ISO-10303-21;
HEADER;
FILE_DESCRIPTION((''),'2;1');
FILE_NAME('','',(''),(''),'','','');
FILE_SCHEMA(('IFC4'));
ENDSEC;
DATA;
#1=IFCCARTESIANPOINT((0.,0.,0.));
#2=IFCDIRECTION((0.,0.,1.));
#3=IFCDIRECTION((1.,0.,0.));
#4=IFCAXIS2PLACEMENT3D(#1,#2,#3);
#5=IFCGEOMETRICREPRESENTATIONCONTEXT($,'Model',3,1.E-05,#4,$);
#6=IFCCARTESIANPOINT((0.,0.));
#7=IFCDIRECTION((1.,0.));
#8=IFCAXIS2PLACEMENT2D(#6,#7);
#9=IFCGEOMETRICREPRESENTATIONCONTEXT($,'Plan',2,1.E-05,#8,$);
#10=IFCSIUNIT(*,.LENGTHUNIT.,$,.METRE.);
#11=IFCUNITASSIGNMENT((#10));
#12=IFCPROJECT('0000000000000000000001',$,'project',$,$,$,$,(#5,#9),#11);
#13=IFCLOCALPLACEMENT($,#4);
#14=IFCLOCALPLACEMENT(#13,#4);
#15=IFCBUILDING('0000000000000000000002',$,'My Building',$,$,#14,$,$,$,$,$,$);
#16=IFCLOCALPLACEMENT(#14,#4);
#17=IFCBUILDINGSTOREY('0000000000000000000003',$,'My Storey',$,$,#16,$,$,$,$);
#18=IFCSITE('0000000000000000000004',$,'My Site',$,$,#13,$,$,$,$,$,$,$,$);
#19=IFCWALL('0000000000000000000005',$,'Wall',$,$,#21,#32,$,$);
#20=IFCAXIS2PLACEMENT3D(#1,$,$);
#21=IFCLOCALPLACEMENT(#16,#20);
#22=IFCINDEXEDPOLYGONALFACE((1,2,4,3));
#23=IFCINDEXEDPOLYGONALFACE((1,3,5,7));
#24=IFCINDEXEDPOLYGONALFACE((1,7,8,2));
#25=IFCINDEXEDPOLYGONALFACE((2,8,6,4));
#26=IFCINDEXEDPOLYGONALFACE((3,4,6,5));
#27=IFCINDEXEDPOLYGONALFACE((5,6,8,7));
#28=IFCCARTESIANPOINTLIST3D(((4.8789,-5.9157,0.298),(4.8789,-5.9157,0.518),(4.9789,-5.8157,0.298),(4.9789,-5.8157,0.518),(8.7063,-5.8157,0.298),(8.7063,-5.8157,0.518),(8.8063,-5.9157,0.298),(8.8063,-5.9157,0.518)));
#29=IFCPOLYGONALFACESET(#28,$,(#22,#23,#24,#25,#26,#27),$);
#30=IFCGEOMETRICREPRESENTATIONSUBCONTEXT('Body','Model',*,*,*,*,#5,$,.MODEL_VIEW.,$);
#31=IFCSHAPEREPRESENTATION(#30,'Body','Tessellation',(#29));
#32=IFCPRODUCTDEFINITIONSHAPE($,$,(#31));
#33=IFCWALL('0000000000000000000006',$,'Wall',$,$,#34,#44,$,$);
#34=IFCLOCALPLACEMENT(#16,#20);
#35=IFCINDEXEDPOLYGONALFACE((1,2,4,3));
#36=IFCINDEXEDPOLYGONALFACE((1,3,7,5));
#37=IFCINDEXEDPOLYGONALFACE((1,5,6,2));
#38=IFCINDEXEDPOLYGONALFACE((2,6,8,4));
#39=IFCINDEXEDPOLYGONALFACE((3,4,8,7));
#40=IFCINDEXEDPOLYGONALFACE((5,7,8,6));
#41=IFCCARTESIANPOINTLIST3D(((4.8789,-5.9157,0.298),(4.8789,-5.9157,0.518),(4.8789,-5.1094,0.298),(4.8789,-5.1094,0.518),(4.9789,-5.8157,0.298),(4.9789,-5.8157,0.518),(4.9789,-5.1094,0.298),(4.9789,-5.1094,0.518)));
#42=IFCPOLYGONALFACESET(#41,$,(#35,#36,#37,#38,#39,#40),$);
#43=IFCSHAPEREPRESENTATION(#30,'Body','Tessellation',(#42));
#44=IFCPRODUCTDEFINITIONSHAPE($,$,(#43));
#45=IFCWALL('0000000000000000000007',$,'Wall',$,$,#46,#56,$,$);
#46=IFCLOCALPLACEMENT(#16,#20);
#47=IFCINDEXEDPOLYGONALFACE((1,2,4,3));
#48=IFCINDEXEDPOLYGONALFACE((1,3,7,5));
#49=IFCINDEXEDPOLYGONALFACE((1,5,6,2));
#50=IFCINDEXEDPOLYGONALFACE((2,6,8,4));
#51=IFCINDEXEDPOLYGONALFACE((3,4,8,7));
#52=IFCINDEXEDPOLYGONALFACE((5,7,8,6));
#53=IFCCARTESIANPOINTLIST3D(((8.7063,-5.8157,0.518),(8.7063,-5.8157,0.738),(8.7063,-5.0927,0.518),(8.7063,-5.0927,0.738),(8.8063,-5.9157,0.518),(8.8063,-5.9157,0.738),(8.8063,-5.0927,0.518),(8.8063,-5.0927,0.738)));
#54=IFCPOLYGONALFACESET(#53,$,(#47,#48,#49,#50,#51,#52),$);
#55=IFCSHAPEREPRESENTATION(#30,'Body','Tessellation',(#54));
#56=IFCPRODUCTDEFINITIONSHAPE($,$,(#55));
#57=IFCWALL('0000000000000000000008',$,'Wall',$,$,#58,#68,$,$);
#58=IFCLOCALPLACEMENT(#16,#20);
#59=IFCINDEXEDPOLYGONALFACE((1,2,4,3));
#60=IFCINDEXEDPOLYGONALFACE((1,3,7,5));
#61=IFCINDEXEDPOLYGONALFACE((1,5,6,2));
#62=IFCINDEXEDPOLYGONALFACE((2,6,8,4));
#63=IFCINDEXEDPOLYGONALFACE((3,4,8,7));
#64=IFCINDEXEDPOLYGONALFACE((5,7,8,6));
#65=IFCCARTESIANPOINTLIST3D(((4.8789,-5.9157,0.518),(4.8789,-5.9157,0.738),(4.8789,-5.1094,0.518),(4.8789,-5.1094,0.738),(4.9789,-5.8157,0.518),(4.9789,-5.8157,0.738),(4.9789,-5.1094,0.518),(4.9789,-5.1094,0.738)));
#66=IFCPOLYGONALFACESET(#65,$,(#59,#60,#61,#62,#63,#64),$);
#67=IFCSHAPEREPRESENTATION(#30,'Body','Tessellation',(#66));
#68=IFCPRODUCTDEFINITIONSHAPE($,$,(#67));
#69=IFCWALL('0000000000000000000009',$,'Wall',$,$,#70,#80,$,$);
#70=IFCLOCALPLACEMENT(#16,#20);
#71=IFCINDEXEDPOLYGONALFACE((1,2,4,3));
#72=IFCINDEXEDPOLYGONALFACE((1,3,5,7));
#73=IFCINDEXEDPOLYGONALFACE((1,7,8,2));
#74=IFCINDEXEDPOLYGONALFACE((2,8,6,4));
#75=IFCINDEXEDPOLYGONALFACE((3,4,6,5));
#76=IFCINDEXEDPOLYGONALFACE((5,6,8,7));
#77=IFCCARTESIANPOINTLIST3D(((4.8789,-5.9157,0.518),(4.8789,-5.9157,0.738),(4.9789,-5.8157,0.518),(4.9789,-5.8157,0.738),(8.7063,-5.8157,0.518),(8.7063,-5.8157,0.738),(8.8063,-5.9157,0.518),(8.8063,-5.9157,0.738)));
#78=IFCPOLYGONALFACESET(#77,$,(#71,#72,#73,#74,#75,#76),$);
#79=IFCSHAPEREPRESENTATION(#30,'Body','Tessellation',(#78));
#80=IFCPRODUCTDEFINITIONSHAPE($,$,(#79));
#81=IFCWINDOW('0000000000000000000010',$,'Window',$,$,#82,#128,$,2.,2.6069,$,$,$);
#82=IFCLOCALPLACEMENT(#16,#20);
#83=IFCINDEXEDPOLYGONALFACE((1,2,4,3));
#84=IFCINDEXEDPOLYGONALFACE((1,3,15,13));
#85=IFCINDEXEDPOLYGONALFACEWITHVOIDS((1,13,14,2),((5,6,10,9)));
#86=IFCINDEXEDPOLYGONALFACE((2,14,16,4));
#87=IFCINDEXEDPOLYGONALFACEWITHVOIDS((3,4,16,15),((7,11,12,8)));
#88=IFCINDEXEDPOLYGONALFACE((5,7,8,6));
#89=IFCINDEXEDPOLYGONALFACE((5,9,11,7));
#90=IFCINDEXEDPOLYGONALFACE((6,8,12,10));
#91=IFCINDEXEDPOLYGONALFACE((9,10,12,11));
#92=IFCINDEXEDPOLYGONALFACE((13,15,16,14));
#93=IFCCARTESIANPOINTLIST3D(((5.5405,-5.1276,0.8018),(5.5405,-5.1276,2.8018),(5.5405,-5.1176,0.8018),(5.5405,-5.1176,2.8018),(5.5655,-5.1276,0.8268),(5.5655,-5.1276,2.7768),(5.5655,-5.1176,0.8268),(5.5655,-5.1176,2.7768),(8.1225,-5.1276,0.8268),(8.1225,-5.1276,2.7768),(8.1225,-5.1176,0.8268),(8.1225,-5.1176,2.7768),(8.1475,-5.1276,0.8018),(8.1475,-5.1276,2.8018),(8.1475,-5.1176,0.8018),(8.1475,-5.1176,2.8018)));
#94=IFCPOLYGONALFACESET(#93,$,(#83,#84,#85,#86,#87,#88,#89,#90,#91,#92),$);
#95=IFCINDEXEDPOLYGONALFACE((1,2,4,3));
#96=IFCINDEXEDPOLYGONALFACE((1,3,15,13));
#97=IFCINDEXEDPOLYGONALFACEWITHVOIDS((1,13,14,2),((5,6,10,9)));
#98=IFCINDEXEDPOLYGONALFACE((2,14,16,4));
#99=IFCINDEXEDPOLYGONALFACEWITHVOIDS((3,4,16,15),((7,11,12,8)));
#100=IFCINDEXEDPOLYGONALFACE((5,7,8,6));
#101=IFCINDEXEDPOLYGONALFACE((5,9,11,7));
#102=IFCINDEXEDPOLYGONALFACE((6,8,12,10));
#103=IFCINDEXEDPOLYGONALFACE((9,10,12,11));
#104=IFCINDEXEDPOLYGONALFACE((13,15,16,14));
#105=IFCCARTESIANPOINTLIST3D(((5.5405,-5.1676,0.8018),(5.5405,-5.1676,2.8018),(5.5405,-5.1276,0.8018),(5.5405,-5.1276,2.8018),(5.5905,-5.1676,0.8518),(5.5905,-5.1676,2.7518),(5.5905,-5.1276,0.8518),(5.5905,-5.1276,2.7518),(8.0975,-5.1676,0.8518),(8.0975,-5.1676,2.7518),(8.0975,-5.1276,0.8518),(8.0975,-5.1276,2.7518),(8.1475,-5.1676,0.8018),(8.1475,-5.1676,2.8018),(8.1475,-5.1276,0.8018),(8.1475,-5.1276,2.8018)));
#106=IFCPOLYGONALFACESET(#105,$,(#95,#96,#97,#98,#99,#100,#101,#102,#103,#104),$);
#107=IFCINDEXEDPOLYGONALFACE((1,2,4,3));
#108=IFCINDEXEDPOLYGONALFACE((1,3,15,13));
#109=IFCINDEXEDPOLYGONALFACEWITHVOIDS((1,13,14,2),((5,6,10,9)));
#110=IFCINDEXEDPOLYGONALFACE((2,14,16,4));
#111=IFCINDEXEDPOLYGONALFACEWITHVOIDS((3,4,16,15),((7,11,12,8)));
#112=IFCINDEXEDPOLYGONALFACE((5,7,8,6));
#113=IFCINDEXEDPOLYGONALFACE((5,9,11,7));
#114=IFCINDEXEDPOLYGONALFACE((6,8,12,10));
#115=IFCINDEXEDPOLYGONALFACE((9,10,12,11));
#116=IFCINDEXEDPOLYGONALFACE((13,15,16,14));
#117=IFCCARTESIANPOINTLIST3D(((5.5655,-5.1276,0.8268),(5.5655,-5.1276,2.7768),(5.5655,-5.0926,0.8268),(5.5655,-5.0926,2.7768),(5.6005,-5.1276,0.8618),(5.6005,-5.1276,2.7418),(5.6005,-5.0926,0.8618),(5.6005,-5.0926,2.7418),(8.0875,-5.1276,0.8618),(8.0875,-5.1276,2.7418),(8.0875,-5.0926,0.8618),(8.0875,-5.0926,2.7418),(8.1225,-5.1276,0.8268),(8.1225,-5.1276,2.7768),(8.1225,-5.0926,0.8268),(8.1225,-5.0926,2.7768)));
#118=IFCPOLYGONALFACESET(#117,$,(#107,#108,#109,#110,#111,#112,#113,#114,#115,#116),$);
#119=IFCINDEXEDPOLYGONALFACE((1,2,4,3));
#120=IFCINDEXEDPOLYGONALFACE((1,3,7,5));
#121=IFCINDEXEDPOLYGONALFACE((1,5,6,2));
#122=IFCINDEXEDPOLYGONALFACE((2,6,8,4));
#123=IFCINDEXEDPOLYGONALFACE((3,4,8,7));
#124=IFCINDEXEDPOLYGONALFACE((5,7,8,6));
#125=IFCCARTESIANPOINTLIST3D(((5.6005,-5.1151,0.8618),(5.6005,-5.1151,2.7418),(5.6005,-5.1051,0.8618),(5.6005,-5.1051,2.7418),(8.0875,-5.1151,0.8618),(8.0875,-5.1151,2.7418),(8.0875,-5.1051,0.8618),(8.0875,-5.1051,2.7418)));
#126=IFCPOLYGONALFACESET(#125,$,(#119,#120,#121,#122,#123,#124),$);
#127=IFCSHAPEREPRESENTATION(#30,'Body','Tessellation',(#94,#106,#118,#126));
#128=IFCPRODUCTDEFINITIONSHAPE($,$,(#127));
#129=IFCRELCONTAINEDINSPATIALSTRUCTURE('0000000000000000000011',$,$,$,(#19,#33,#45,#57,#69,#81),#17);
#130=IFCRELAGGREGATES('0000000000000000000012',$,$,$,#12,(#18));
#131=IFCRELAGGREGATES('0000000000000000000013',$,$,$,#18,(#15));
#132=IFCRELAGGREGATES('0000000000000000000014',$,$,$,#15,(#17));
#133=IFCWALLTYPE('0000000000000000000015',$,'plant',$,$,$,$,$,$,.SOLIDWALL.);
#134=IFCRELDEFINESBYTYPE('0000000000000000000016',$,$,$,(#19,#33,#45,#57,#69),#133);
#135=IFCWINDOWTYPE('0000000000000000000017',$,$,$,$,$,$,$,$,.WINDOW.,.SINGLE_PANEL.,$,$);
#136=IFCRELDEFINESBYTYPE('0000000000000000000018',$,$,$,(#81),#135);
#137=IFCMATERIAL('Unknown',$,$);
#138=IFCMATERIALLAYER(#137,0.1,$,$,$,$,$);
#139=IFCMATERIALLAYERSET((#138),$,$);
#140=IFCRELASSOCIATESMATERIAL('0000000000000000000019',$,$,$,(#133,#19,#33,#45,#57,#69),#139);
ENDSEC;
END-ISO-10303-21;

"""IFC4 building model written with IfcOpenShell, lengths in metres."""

from ifc_helpers import new_model, entity, si_unit, frame, origin_with_axes, origin_2d_with_axis, place, context, subcontext, project, spatial, line, indexed_curve, outline, extrude, shape, source, transform, mapped, material, layer, layer_set, layer_usage, type_object, type_shapes, element, save


model = new_model("IFC4")

# Units and contexts
model_context = context("Model", 3, precision=1e-05, world=origin_with_axes())
plan_context = context("Plan", 2, precision=1e-05, world=origin_2d_with_axis())
body_context_1 = subcontext(model_context, "Body", "Model", "MODEL_VIEW")
body_context_2 = subcontext(plan_context, "Body", "Plan", "PLAN_VIEW")
ifc_project = project(units=[si_unit("LENGTHUNIT", "METRE")], contexts=[model_context, plan_context])

# Site, building, storey
site_placement = place(None, origin_with_axes())
site = spatial("IfcSite", under=ifc_project, at=site_placement, Name="My Site")
building_placement = place(site_placement, origin_with_axes())
building = spatial("IfcBuilding", under=site, at=building_placement, Name="My Building")
storey_placement = place(building_placement, origin_with_axes())
storey = spatial("IfcBuildingStorey", under=building, at=storey_placement, Name="My Storey")

# Shared definitions
ifc_material = material(Name="Unknown")

# Walls
ifc_layer_1 = layer(ifc_material, 0.1)
ifc_layer_set_1 = layer_set([ifc_layer_1])
wall_type = type_object("IfcWallType", Name="plant", PredefinedType="SOLIDWALL", material=ifc_layer_set_1)
ifc_layer_usage_1 = layer_usage(ifc_layer_set_1, "AXIS2", "POSITIVE", 0.0)
wall_1_placement = place(storey_placement, frame((8.7063, -5.8157, 0.298), z_axis=(0.0, 0.0, 1.0), x_axis=(-1.0, 0.0, 0.0)))
element("IfcWall", 1, at=wall_1_placement, inside=storey, type_object=wall_type, material=ifc_layer_usage_1, Name="Wall", context=body_context_1, shape_type="SweptSolid", body=[
    extrude(outline(indexed_curve([(0.0, 0.0), (-0.1, 0.1), (3.8274, 0.1), (3.7274, 0.0)], segments=[line(1, 2, 3, 4, 1)])), origin_with_axes(), (0.0, 0.0, 1.0), 0.22),
])
ifc_layer_usage_2 = layer_usage(ifc_layer_set_1, "AXIS2", "POSITIVE", 0.0)
wall_2_placement = place(storey_placement, frame((4.9789, -5.8157, 0.298), z_axis=(0.0, 0.0, 1.0), x_axis=(0.0, 1.0, 0.0)))
element("IfcWall", 2, at=wall_2_placement, inside=storey, type_object=wall_type, material=ifc_layer_usage_2, Name="Wall", context=body_context_1, shape_type="SweptSolid", body=[
    extrude(outline(indexed_curve([(0.0, 0.0), (-0.1, 0.1), (0.7063, 0.1), (0.7063, 0.0)], segments=[line(1, 2, 3, 4, 1)])), origin_with_axes(), (0.0, 0.0, 1.0), 0.22),
])
ifc_layer_usage_3 = layer_usage(ifc_layer_set_1, "AXIS2", "POSITIVE", 0.0)
wall_3_placement = place(storey_placement, frame((8.7063, -5.0927, 0.518), z_axis=(0.0, 0.0, 1.0), x_axis=(0.0, -1.0, 0.0)))
element("IfcWall", 3, at=wall_3_placement, inside=storey, type_object=wall_type, material=ifc_layer_usage_3, Name="Wall", context=body_context_1, shape_type="SweptSolid", body=[
    extrude(outline(indexed_curve([(0.0, 0.0), (0.0, 0.1), (0.823, 0.1), (0.723, 0.0)], segments=[line(1, 2, 3, 4, 1)])), origin_with_axes(), (0.0, 0.0, 1.0), 0.22),
])
ifc_layer_usage_4 = layer_usage(ifc_layer_set_1, "AXIS2", "POSITIVE", 0.0)
wall_4_placement = place(storey_placement, frame((4.9789, -5.8157, 0.518), z_axis=(0.0, 0.0, 1.0), x_axis=(0.0, 1.0, 0.0)))
element("IfcWall", 4, at=wall_4_placement, inside=storey, type_object=wall_type, material=ifc_layer_usage_4, Name="Wall", context=body_context_1, shape_type="SweptSolid", body=[
    extrude(outline(indexed_curve([(0.0, 0.0), (-0.1, 0.1), (0.7063, 0.1), (0.7063, 0.0)], segments=[line(1, 2, 3, 4, 1)])), origin_with_axes(), (0.0, 0.0, 1.0), 0.22),
])
ifc_layer_usage_5 = layer_usage(ifc_layer_set_1, "AXIS2", "POSITIVE", 0.0)
wall_5_placement = place(storey_placement, frame((8.7063, -5.8157, 0.518), z_axis=(0.0, 0.0, 1.0), x_axis=(-1.0, 0.0, 0.0)))
element("IfcWall", 5, at=wall_5_placement, inside=storey, type_object=wall_type, material=ifc_layer_usage_5, Name="Wall", context=body_context_1, shape_type="SweptSolid", body=[
    extrude(outline(indexed_curve([(0.0, 0.0), (-0.1, 0.1), (3.8274, 0.1), (3.7274, 0.0)], segments=[line(1, 2, 3, 4, 1)])), origin_with_axes(), (0.0, 0.0, 1.0), 0.22),
])

# Window
window_type = type_object("IfcWindowType", PartitioningType="SINGLE_PANEL", PredefinedType="WINDOW")
shared_shape_1 = source(origin_with_axes(), body_context_1, "Body", "SweptSolid", [
    extrude(outline(indexed_curve([(0.0, 0.0), (2.6069, 0.0), (2.6069, 2.0), (0.0, 2.0)], segments=[line(1, 2, 3, 4, 1)]), holes=[indexed_curve([(0.025, 0.025), (2.5819, 0.025), (2.5819, 1.975), (0.025, 1.975)], segments=[line(1, 2, 3, 4, 1)])]), frame((0.0, 0.09, 0.0), z_axis=(0.0, -1.0, 0.0), x_axis=(1.0, 0.0, 0.0)), (0.0, 0.0, -1.0), 0.01),
    extrude(outline(indexed_curve([(0.0, 0.0), (2.6069, 0.0), (2.6069, 2.0), (0.0, 2.0)], segments=[line(1, 2, 3, 4, 1)]), holes=[indexed_curve([(0.05, 0.05), (2.5569, 0.05), (2.5569, 1.95), (0.05, 1.95)], segments=[line(1, 2, 3, 4, 1)])]), frame((0.0, 0.05, 0.0), z_axis=(0.0, -1.0, 0.0), x_axis=(1.0, 0.0, 0.0)), (0.0, 0.0, -1.0), 0.04),
    extrude(outline(indexed_curve([(0.0, 1.95), (2.5569, 1.95), (2.5569, 0.0), (0.0, 0.0), (0.0, 1.95)]), holes=[indexed_curve([(0.035, 1.915), (2.5219, 1.915), (2.5219, 0.035), (0.035, 0.035), (0.035, 1.915)])]), frame((0.025, 0.09, 0.025), z_axis=(0.0, -1.0, 0.0), x_axis=(1.0, 0.0, 0.0)), (0.0, 0.0, -1.0), 0.035),
    extrude(outline(indexed_curve([(0.035, 0.035), (2.5219, 0.035), (2.5219, 1.915), (0.035, 1.915)], segments=[line(1, 2, 3, 4, 1)])), frame((0.025, 0.1025, 0.025), z_axis=(0.0, -1.0, 0.0), x_axis=(1.0, 0.0, 0.0)), (0.0, 0.0, -1.0), 0.01),
])
shared_shape_2 = source(origin_with_axes(), body_context_2, "Body", "Curve2D", [
    entity("IfcIndexedPolyCurve", entity("IfcCartesianPointList2D", [[0.05, 0.05], [2.5569, 0.05]])),
    entity("IfcIndexedPolyCurve", entity("IfcCartesianPointList2D", [[0.0, 0.1], [0.025, 0.1], [0.025, 0.09], [0.05, 0.09], [0.05, 0.05], [0.0, 0.05]]), [entity("IfcLineIndex", [1, 2, 3, 4, 5, 6, 1])]),
    entity("IfcIndexedPolyCurve", entity("IfcCartesianPointList2D", [[2.6069, 0.1], [2.5819, 0.1], [2.5819, 0.09], [2.5569, 0.09], [2.5569, 0.05], [2.6069, 0.05]]), [entity("IfcLineIndex", [1, 2, 3, 4, 5, 6, 1])]),
    entity("IfcIndexedPolyCurve", entity("IfcCartesianPointList2D", [[0.025, 0.09], [0.06, 0.09], [0.06, 0.125], [0.025, 0.125]]), [entity("IfcLineIndex", [1, 2, 3, 4, 1])]),
    entity("IfcIndexedPolyCurve", entity("IfcCartesianPointList2D", [[2.5819, 0.09], [2.5469, 0.09], [2.5469, 0.125], [2.5819, 0.125]]), [entity("IfcLineIndex", [1, 2, 3, 4, 1])]),
    entity("IfcIndexedPolyCurve", entity("IfcCartesianPointList2D", [[0.06, 0.09], [2.5469, 0.09]])),
    entity("IfcIndexedPolyCurve", entity("IfcCartesianPointList2D", [[0.06, 0.125], [2.5469, 0.125]])),
    entity("IfcIndexedPolyCurve", entity("IfcCartesianPointList2D", [[0.06, 0.1075], [2.5469, 0.1075]])),
])
type_shapes(window_type, [shared_shape_1, shared_shape_2])
window_placement = place(storey_placement, frame((5.5405, -5.2176, 0.8018), z_axis=(0.0, 0.0, 1.0), x_axis=(1.0, 0.0, 0.0)))
element("IfcWindow", 6, at=window_placement, inside=storey, type_object=window_type, Name="Window", OverallHeight=2.0, OverallWidth=2.6069, shapes=[
    shape(body_context_1, "Body", "MappedRepresentation", [mapped(shared_shape_1, transform((0.0, 0.0, 0.0), x_axis=(1.0, 0.0, 0.0), y_axis=(0.0, 1.0, 0.0), z_axis=(0.0, 0.0, 1.0), scale=1.0))]),
    shape(body_context_2, "Body", "MappedRepresentation", [mapped(shared_shape_2, transform((0.0, 0.0, 0.0), x_axis=(1.0, 0.0, 0.0), y_axis=(0.0, 1.0, 0.0), z_axis=(0.0, 0.0, 1.0), scale=1.0))]),
])

save(model, "model.ifc")
